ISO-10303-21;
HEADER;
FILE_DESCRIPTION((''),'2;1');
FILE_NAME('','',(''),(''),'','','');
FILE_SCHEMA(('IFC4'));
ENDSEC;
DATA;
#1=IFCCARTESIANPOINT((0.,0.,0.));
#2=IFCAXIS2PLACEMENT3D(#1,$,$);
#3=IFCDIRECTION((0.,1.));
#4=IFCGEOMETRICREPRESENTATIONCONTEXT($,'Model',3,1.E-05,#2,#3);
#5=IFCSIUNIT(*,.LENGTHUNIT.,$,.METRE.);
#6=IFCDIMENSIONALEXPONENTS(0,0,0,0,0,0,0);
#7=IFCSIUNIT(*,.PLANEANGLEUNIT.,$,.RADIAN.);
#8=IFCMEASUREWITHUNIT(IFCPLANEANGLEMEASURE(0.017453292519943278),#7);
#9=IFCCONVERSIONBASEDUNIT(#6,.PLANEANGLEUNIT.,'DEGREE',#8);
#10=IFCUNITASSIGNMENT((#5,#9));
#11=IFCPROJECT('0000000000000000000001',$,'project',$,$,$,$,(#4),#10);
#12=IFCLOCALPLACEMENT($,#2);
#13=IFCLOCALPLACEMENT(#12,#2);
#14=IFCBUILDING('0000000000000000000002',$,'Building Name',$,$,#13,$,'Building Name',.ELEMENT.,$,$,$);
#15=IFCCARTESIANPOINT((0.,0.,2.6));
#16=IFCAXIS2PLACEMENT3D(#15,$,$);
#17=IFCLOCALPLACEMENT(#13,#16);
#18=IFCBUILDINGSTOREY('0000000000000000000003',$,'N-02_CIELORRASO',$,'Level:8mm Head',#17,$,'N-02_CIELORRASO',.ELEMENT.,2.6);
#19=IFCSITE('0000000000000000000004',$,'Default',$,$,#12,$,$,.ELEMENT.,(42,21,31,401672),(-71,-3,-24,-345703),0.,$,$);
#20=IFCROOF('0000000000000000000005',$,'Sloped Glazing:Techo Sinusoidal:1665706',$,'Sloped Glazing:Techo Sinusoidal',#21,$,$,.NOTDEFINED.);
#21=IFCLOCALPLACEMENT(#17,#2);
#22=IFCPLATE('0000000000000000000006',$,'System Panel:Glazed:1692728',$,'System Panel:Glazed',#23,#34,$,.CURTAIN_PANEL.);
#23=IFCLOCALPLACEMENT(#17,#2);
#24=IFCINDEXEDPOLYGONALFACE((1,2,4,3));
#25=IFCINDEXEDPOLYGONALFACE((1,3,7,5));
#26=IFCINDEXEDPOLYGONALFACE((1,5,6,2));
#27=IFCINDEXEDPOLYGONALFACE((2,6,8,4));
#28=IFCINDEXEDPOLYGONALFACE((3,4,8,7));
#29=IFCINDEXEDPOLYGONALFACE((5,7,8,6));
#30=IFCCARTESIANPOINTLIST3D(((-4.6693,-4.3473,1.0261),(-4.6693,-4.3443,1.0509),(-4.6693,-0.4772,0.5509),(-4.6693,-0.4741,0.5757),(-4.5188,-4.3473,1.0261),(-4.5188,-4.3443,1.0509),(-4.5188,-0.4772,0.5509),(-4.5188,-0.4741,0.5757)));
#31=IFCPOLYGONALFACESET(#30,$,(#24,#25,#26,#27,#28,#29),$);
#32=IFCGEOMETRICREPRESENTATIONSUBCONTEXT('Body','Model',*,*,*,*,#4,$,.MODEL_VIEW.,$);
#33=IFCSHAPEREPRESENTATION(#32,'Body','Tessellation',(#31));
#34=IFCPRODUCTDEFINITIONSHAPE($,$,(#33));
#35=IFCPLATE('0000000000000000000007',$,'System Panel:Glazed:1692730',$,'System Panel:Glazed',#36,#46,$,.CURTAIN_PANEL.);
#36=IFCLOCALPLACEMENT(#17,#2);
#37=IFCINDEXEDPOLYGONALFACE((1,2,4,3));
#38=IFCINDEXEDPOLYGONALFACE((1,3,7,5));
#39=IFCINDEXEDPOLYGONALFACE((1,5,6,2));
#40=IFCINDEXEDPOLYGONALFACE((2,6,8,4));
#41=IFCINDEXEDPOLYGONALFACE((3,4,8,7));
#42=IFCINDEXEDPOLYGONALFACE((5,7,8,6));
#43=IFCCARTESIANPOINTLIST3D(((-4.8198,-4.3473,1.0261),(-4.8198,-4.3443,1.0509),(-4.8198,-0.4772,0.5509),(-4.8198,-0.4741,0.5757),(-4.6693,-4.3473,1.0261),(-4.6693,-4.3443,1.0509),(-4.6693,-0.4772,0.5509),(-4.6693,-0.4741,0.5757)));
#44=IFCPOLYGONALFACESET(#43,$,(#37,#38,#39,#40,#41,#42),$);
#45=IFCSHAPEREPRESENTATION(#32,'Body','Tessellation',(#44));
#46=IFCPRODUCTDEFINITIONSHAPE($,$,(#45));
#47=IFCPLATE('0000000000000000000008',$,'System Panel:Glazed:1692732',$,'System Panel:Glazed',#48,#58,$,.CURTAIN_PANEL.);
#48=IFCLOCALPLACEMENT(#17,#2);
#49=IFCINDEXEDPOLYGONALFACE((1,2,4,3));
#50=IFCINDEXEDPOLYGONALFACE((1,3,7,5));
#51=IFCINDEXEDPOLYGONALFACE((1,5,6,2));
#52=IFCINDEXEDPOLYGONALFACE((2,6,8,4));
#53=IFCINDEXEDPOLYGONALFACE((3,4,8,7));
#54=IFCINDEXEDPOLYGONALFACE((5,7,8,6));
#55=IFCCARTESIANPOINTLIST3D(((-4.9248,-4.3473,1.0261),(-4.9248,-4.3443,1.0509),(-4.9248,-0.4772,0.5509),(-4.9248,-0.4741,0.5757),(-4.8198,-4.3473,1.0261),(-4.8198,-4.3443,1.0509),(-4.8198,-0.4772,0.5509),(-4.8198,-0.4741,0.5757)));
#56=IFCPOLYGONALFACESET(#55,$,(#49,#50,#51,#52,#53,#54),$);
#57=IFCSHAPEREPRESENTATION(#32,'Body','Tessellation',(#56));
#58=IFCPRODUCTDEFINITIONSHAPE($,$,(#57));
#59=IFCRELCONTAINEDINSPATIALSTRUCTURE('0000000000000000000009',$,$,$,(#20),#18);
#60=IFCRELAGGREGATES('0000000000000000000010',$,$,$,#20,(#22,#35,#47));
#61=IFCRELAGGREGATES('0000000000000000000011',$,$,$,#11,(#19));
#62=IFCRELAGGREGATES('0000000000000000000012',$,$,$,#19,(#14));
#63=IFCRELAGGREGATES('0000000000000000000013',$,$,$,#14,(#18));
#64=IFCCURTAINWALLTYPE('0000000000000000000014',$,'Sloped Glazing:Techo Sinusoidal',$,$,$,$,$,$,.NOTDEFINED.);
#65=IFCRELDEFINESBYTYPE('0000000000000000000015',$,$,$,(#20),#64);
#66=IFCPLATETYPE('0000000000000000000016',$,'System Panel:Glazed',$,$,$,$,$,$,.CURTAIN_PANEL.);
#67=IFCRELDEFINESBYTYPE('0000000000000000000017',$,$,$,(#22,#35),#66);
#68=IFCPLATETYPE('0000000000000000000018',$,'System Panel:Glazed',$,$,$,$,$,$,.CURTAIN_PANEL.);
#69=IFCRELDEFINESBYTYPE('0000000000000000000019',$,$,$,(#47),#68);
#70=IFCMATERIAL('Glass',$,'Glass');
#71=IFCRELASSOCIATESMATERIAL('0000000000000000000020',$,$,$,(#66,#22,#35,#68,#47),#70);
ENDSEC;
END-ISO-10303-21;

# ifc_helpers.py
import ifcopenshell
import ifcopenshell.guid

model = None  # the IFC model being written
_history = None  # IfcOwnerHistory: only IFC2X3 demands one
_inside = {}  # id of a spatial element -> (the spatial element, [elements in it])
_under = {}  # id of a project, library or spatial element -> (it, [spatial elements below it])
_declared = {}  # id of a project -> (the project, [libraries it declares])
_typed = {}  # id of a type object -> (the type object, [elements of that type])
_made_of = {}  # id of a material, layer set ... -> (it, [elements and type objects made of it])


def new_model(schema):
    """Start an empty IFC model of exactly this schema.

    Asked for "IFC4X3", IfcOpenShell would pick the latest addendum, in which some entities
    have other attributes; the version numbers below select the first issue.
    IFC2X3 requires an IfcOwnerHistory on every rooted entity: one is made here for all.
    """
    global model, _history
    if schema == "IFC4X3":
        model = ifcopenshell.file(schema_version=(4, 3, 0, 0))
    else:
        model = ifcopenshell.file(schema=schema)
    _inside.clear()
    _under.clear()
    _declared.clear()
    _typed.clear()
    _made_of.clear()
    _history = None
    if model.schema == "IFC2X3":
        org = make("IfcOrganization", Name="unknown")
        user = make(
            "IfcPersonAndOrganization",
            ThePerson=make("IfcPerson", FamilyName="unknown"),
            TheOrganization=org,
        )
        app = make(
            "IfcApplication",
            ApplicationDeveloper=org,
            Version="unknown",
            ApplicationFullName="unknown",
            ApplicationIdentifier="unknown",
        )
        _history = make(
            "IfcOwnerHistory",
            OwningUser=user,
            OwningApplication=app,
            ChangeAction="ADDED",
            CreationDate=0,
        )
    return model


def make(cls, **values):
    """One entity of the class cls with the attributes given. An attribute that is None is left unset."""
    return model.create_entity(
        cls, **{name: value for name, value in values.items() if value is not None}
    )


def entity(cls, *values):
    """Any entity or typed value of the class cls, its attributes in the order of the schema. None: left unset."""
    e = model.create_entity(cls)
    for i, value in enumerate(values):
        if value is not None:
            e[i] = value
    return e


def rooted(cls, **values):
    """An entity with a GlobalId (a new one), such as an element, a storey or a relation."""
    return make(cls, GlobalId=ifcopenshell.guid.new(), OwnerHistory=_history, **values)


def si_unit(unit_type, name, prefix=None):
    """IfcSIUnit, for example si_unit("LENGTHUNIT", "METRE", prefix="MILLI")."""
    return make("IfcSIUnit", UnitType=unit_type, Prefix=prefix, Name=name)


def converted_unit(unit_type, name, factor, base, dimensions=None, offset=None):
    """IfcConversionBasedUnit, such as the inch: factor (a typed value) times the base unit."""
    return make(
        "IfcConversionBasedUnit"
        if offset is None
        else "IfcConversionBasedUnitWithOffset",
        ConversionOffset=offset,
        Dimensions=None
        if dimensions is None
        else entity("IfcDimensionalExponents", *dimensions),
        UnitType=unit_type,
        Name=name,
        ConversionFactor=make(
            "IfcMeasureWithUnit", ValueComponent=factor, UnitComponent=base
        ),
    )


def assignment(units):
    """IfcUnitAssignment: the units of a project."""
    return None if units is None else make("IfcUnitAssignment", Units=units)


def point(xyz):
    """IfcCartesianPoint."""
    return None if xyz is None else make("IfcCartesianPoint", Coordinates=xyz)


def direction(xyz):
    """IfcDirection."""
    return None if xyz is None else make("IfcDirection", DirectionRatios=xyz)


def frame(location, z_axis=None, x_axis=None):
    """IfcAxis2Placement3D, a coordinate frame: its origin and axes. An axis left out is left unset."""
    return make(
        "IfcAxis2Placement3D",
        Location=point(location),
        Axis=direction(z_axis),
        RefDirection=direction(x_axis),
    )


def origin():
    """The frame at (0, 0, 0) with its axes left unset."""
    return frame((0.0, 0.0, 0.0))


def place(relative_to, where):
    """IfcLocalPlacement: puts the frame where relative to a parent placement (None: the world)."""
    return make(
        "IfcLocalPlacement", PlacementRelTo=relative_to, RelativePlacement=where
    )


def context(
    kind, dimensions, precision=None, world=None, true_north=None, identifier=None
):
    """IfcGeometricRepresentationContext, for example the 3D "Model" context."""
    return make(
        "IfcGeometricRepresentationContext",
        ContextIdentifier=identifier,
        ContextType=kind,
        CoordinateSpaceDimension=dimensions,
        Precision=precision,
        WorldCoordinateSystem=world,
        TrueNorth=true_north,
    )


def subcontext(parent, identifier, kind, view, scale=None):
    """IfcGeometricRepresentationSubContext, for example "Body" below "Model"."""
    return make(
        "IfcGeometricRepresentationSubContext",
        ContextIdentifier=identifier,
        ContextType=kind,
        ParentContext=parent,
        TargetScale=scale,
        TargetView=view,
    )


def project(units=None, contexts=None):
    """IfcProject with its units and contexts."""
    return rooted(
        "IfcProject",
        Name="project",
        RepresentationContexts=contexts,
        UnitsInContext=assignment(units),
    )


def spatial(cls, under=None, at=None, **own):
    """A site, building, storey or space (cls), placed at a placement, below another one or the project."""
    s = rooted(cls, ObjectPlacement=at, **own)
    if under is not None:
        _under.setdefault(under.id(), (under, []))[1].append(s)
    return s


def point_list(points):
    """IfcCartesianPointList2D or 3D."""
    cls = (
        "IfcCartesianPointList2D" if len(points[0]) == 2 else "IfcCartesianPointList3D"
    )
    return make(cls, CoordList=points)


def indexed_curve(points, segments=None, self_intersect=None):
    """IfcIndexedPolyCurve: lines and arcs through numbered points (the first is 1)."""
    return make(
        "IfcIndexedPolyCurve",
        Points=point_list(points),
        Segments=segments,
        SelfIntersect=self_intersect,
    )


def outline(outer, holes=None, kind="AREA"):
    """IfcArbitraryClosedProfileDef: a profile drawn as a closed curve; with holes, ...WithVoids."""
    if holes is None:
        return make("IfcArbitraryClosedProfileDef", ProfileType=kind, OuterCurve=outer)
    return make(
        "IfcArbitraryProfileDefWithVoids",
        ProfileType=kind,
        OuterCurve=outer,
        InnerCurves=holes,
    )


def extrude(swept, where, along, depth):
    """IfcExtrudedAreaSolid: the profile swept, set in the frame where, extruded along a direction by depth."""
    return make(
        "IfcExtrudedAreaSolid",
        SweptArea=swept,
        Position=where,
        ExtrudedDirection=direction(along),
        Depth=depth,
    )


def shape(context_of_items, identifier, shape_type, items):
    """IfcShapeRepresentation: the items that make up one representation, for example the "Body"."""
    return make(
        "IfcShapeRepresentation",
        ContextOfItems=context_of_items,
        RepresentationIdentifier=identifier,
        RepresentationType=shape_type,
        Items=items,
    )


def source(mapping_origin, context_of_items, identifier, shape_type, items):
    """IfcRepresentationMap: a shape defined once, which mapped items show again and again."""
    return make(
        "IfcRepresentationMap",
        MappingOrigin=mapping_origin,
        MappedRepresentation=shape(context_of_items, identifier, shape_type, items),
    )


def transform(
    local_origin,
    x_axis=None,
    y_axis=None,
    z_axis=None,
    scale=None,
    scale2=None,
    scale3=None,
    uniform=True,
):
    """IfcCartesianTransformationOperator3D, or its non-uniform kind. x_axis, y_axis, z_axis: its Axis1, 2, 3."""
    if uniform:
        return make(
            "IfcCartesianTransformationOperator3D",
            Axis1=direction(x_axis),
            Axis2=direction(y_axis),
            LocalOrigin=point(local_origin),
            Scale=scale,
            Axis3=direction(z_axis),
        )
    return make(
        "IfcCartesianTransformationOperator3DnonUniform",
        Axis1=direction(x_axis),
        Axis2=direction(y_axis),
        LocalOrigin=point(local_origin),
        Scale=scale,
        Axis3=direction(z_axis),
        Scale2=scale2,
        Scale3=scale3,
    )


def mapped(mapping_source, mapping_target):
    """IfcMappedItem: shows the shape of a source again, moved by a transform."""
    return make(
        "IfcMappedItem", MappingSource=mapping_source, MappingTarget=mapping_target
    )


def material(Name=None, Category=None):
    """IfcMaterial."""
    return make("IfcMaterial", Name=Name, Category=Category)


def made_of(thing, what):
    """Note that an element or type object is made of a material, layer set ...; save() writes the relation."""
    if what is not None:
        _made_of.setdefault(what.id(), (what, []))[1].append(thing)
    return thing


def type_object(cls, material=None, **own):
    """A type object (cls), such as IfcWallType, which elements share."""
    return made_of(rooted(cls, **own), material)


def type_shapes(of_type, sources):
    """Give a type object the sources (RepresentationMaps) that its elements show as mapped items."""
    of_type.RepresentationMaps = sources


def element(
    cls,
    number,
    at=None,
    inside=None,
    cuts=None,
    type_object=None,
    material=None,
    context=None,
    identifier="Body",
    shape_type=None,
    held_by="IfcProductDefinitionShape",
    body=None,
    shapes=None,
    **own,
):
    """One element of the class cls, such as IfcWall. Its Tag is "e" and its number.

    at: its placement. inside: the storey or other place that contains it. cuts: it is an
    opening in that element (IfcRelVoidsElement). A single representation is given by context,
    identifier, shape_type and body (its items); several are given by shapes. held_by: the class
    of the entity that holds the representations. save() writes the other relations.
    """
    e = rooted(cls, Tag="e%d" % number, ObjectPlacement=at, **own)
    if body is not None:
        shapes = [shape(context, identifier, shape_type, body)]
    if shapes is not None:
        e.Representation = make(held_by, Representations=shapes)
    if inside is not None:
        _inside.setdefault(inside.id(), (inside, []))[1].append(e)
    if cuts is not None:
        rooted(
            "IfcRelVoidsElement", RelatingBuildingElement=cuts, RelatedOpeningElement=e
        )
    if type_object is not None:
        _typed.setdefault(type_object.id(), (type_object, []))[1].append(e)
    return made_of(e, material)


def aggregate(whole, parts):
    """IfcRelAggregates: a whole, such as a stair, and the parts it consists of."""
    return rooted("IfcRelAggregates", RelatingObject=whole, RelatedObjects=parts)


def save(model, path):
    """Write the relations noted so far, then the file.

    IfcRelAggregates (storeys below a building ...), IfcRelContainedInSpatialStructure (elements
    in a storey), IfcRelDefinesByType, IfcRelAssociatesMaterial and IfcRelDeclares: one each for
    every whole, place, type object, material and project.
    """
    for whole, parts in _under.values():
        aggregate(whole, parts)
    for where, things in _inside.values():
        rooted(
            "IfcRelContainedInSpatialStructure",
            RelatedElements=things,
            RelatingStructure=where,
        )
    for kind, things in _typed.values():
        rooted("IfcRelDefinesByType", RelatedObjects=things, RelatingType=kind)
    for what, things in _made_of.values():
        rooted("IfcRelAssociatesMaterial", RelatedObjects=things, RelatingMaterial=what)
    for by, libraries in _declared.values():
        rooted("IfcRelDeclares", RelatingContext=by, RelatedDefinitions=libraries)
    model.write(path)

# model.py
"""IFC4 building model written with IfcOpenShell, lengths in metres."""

from ifc_helpers import new_model, entity, si_unit, converted_unit, direction, frame, origin, place, context, subcontext, project, spatial, indexed_curve, outline, extrude, source, transform, mapped, material, type_object, type_shapes, element, aggregate, save


model = new_model("IFC4")

# Units and contexts
model_context = context("Model", 3, precision=1e-05, world=origin(), true_north=direction((0.0, 1.0)))
body_context = subcontext(model_context, "Body", "Model", "MODEL_VIEW")
ifc_project = project(units=[si_unit("LENGTHUNIT", "METRE"), converted_unit("PLANEANGLEUNIT", "DEGREE", entity("IfcPlaneAngleMeasure", 0.017453292519943278), si_unit("PLANEANGLEUNIT", "RADIAN"), dimensions=[0, 0, 0, 0, 0, 0, 0])], contexts=[model_context])

# Site, building, storey
site_placement = place(None, origin())
site = spatial("IfcSite", under=ifc_project, at=site_placement, Name="Default", CompositionType="ELEMENT", RefLatitude=(42, 21, 31, 401672), RefLongitude=(-71, -3, -24, -345703), RefElevation=0.0)
building_placement = place(site_placement, origin())
building = spatial("IfcBuilding", under=site, at=building_placement, Name="Building Name", LongName="Building Name", CompositionType="ELEMENT")
storey_placement = place(building_placement, frame((0.0, 0.0, 2.6)))
storey = spatial("IfcBuildingStorey", under=building, at=storey_placement, Name="N-02_CIELORRASO", ObjectType="Level:8mm Head", LongName="N-02_CIELORRASO", CompositionType="ELEMENT", Elevation=2.6)

# Shared definitions
curtain_wall_type = type_object("IfcCurtainWallType", Name="Sloped Glazing:Techo Sinusoidal", PredefinedType="NOTDEFINED")

# Roof, plates
roof_1_placement = place(storey_placement, frame((0.0, 0.0, -2.6)))
roof_1 = element("IfcRoof", 1, at=roof_1_placement, inside=storey, type_object=curtain_wall_type, Name="Sloped Glazing:Techo Sinusoidal:1665706", ObjectType="Sloped Glazing:Techo Sinusoidal", PredefinedType="NOTDEFINED")
ifc_material_1 = material(Name="Glass", Category="Glass")
plate_type_1 = type_object("IfcPlateType", Name="System Panel:Glazed", PredefinedType="CURTAIN_PANEL", material=ifc_material_1)
shared_shape_1 = source(origin(), body_context, "Body", "SweptSolid", [
    extrude(outline(indexed_curve([(-0.0125, -0.0753), (0.0125, -0.0753), (0.0125, 0.0753), (-0.0125, 0.0753), (-0.0125, -0.0753)], self_intersect=False)), frame((0.0, 0.037, 0.0), z_axis=(0.0, 0.0, 1.0), x_axis=(0.0, 1.0, 0.0)), (0.0, 0.0, 1.0), 3.8992),
])
type_shapes(plate_type_1, [shared_shape_1])
plate_1_placement = place(roof_1_placement, frame((-4.594, -0.4711, 3.2), z_axis=(0.0, -0.992546, 0.121869), x_axis=(-1.0, 0.0, 0.0)))
plate_1 = element("IfcPlate", 2, at=plate_1_placement, type_object=plate_type_1, material=ifc_material_1, Name="System Panel:Glazed:1692728", ObjectType="System Panel:Glazed", PredefinedType="CURTAIN_PANEL", context=body_context, shape_type="MappedRepresentation", body=[
    mapped(shared_shape_1, transform((0.0, 0.0, 0.0), scale=1.0)),
])
plate_2_placement = place(roof_1_placement, frame((-4.7445, -0.4711, 3.2), z_axis=(0.0, -0.992546, 0.121869), x_axis=(-1.0, 0.0, 0.0)))
plate_2 = element("IfcPlate", 3, at=plate_2_placement, type_object=plate_type_1, material=ifc_material_1, Name="System Panel:Glazed:1692730", ObjectType="System Panel:Glazed", PredefinedType="CURTAIN_PANEL", context=body_context, shape_type="MappedRepresentation", body=[
    mapped(shared_shape_1, transform((0.0, 0.0, 0.0), scale=1.0)),
])
plate_type_2 = type_object("IfcPlateType", Name="System Panel:Glazed", PredefinedType="CURTAIN_PANEL", material=ifc_material_1)
shared_shape_2 = source(origin(), body_context, "Body", "SweptSolid", [
    extrude(outline(indexed_curve([(-0.0125, -0.0525), (0.0125, -0.0525), (0.0125, 0.0525), (-0.0125, 0.0525), (-0.0125, -0.0525)], self_intersect=False)), frame((0.0, 0.037, 0.0), z_axis=(0.0, 0.0, 1.0), x_axis=(0.0, 1.0, 0.0)), (0.0, 0.0, 1.0), 3.8992),
])
type_shapes(plate_type_2, [shared_shape_2])
plate_3_placement = place(roof_1_placement, frame((-4.8723, -0.4711, 3.2), z_axis=(0.0, -0.992546, 0.121869), x_axis=(-1.0, 0.0, 0.0)))
plate_3 = element("IfcPlate", 4, at=plate_3_placement, type_object=plate_type_2, material=ifc_material_1, Name="System Panel:Glazed:1692732", ObjectType="System Panel:Glazed", PredefinedType="CURTAIN_PANEL", context=body_context, shape_type="MappedRepresentation", body=[
    mapped(shared_shape_2, transform((0.0, 0.0, 0.0), scale=1.0)),
])
aggregate(roof_1, [plate_1, plate_2, plate_3])

save(model, "model.ifc")
